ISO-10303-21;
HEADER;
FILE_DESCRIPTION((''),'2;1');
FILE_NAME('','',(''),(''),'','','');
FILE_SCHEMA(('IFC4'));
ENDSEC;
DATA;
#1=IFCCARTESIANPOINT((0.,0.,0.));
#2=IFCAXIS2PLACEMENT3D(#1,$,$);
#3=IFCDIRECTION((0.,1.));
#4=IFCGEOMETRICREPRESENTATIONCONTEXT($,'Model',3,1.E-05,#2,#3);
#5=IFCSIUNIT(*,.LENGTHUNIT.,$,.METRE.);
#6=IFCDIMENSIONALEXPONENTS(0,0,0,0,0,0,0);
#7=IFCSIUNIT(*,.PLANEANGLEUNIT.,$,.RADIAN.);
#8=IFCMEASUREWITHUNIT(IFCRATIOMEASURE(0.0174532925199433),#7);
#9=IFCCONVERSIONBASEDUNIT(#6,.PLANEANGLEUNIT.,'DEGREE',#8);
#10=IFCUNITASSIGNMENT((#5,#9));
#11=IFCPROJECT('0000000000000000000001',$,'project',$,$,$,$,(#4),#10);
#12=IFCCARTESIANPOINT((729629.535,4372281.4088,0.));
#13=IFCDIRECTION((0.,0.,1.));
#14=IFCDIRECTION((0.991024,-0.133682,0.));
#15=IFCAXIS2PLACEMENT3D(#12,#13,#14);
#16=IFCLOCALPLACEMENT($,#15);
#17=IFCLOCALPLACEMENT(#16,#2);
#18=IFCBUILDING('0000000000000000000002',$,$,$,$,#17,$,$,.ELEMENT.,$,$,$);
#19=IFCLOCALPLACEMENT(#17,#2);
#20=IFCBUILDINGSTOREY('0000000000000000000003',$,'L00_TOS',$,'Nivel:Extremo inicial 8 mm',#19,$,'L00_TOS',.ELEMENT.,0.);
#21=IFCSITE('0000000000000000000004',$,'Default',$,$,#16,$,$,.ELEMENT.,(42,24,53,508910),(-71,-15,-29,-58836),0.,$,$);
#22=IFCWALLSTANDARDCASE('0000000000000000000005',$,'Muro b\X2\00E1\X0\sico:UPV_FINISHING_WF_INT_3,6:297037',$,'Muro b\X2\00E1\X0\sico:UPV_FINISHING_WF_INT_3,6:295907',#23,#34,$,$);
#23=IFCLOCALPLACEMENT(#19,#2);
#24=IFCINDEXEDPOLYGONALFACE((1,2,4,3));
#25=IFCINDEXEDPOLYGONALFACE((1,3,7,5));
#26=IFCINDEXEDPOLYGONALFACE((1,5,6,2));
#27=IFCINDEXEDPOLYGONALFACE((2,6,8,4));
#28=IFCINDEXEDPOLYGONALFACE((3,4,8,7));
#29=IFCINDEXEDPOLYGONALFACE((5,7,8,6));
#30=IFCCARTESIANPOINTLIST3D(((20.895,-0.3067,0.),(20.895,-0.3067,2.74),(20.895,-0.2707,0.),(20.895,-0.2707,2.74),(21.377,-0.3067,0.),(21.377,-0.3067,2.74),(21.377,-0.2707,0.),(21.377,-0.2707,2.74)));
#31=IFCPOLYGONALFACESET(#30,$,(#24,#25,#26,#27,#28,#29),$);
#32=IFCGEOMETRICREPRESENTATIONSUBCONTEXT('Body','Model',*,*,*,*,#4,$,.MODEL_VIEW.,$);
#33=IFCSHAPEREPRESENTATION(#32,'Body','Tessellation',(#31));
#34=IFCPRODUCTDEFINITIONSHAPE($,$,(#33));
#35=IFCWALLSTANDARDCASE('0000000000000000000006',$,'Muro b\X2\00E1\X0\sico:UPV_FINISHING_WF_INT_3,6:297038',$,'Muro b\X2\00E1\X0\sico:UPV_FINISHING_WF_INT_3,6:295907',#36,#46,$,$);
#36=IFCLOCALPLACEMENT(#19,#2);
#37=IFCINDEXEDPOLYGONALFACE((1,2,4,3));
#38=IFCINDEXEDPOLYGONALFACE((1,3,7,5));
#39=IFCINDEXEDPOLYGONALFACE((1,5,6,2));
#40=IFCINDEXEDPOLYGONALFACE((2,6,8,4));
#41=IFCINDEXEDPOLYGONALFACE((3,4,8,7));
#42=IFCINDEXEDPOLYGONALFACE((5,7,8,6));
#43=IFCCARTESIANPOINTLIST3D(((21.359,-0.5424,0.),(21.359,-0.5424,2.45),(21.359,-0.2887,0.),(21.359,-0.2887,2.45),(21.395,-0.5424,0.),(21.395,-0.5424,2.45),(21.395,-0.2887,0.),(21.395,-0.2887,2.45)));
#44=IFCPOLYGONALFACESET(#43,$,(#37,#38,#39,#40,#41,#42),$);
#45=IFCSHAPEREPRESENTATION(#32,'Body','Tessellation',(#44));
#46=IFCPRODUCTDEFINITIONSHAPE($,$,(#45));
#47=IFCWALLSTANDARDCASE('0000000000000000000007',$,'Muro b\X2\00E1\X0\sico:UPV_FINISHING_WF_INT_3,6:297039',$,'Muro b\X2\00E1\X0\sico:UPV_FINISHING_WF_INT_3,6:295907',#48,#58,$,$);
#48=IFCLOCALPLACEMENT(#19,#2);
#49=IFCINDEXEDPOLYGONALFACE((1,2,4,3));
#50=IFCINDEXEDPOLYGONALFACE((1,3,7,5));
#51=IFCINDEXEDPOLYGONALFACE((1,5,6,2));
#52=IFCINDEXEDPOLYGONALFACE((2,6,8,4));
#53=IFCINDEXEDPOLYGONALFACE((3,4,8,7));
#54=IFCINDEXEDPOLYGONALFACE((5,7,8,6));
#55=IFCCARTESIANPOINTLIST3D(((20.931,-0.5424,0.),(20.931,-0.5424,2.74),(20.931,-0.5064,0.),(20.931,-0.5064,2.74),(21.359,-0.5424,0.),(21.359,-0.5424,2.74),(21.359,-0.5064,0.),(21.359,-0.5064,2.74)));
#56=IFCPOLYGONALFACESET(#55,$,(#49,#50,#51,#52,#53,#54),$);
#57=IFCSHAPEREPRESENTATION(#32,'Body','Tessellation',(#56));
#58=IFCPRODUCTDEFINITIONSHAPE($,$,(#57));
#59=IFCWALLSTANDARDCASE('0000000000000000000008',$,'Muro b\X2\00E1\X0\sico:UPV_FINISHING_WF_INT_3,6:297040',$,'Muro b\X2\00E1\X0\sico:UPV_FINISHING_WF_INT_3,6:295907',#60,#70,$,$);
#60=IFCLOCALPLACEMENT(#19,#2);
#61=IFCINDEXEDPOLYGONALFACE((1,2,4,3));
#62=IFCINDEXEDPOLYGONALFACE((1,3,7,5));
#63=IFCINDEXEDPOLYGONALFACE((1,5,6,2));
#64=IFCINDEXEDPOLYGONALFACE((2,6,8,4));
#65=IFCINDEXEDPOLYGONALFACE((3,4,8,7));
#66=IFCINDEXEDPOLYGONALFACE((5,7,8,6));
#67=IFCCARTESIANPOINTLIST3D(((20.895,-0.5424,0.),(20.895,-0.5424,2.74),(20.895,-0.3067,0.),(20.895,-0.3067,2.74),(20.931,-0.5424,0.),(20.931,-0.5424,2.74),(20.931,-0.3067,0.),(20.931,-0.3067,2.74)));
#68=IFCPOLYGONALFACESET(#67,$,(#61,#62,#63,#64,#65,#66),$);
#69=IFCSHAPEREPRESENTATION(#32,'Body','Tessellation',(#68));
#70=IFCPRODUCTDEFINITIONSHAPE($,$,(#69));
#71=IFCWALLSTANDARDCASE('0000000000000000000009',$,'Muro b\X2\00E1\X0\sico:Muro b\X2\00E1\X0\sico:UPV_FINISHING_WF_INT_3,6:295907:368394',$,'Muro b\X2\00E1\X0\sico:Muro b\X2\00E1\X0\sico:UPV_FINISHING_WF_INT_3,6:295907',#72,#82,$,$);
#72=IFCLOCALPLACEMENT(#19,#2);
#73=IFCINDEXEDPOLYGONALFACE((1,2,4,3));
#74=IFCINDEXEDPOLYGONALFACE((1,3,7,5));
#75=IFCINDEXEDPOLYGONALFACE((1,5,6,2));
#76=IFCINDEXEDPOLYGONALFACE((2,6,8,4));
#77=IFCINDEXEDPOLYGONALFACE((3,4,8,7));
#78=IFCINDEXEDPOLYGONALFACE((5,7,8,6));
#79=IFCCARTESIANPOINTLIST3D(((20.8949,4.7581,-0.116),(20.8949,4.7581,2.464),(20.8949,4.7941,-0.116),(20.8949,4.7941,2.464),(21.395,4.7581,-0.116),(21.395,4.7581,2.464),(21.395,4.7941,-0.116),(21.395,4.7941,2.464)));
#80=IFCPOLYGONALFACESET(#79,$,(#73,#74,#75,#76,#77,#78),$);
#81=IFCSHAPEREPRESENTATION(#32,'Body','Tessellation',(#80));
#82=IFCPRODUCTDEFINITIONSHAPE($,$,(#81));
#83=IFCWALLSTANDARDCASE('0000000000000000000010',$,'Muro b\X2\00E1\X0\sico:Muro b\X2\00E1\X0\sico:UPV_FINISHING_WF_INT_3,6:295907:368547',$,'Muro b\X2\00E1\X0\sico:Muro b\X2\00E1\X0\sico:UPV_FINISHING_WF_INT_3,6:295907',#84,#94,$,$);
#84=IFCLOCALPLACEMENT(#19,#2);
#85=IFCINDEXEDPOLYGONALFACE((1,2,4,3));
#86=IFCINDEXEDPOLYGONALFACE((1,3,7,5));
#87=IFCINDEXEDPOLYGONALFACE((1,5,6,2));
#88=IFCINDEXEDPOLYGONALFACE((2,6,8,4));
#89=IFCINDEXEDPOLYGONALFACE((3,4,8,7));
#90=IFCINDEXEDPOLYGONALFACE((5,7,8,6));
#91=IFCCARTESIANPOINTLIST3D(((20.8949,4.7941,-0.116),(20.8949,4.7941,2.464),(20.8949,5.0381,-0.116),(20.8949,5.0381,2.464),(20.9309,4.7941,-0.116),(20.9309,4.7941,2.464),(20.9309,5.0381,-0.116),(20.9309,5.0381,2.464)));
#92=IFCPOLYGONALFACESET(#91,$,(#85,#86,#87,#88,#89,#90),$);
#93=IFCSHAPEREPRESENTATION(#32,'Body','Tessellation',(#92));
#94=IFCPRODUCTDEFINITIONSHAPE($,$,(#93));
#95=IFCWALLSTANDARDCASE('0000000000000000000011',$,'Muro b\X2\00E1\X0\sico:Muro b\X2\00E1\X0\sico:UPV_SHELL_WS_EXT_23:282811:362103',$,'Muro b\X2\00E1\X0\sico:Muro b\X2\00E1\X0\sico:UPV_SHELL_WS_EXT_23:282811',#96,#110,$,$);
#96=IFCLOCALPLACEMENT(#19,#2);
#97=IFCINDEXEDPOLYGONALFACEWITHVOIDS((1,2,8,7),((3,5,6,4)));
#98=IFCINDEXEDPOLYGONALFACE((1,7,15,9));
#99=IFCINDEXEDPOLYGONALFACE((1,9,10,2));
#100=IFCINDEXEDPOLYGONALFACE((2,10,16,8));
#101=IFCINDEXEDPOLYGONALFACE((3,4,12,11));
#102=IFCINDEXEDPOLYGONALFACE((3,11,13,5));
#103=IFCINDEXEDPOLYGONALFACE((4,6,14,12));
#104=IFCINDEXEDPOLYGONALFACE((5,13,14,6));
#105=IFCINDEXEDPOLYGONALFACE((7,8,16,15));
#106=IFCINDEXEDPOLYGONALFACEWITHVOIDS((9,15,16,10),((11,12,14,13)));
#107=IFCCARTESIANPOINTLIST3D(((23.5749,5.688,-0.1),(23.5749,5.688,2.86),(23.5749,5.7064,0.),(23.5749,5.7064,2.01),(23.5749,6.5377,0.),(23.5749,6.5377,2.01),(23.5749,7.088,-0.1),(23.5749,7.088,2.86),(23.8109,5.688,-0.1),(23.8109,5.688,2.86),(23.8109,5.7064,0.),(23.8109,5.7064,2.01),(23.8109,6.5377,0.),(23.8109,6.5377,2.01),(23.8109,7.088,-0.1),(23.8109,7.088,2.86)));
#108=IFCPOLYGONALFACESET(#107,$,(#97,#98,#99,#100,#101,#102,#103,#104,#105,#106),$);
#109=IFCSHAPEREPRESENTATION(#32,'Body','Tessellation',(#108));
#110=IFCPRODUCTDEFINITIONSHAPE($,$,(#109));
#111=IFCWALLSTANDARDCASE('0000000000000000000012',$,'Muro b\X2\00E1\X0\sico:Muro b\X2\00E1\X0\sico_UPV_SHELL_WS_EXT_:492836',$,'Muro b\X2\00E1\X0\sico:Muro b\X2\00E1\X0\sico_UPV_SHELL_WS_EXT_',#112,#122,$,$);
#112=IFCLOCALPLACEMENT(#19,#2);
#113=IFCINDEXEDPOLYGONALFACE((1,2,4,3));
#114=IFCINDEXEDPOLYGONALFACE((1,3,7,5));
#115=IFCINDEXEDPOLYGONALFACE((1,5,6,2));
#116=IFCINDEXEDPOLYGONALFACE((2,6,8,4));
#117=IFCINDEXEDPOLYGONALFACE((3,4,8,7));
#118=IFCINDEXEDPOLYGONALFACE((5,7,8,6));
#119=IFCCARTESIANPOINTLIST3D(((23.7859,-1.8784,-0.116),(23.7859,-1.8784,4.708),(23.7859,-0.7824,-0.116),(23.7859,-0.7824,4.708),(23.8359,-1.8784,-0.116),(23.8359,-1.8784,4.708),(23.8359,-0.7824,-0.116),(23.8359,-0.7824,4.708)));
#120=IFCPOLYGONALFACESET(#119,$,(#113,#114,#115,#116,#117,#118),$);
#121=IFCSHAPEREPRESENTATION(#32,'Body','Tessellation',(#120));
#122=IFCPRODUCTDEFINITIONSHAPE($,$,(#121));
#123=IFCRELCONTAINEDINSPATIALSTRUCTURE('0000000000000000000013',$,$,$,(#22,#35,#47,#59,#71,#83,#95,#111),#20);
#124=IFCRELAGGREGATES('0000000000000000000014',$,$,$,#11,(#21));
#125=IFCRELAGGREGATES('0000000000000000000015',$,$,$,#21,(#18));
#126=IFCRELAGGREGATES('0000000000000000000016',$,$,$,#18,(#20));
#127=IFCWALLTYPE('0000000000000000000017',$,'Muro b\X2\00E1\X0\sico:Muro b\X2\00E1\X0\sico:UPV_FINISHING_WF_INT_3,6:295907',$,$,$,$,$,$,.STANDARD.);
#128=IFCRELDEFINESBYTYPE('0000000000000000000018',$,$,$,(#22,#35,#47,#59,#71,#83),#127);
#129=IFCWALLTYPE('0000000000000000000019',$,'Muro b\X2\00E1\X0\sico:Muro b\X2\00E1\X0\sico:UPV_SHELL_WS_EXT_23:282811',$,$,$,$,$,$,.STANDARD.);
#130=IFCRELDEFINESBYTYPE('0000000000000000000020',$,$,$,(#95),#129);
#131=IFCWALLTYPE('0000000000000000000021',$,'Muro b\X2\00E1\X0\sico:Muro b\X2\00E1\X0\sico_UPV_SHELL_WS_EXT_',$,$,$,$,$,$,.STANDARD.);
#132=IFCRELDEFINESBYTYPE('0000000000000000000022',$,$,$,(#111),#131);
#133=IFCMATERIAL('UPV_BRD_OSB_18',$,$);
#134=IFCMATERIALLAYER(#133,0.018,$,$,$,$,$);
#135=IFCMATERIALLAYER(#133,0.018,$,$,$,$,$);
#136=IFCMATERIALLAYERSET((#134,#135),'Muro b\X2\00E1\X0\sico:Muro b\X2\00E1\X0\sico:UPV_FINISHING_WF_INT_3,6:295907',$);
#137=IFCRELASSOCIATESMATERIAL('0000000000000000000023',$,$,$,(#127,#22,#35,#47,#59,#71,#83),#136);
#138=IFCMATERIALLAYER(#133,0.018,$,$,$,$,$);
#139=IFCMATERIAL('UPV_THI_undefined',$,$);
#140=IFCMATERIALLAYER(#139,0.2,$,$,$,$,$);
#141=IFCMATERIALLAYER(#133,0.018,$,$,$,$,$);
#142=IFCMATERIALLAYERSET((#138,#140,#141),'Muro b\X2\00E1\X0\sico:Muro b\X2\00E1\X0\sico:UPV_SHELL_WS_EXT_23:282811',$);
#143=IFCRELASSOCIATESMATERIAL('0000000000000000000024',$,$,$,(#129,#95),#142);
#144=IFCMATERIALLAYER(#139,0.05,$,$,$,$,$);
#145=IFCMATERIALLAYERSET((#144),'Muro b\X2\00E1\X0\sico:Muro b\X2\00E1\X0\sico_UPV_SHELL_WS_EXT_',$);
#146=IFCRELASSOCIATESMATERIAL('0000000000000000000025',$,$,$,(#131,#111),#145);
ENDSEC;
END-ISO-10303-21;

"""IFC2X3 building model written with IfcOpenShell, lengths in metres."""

from ifc_helpers import new_model, entity, si_unit, converted_unit, direction, frame, frame_2d, origin, place, context, subcontext, project, spatial, rectangle, extrude, material, layer, layer_set, layer_usage, type_object, element, save


model = new_model("IFC2X3")

# Units and contexts
model_context = context("Model", 3, precision=1e-05, world=origin(), true_north=direction((0.0, 1.0)))
body_context = subcontext(model_context, "Body", "Model", "MODEL_VIEW")
ifc_project = project(units=[si_unit("LENGTHUNIT", "METRE"), converted_unit("PLANEANGLEUNIT", "DEGREE", entity("IfcRatioMeasure", 0.0174532925199433), si_unit("PLANEANGLEUNIT", "RADIAN"), dimensions=[0, 0, 0, 0, 0, 0, 0])], contexts=[model_context])

# Site, building, storey
site_placement = place(None, frame((729629.535, 4372281.4088, 0.0), z_axis=(0.0, 0.0, 1.0), x_axis=(0.991024, -0.133682, 0.0)))
site = spatial("IfcSite", under=ifc_project, at=site_placement, Name="Default", CompositionType="ELEMENT", RefLatitude=(42, 24, 53, 508910), RefLongitude=(-71, -15, -29, -58836), RefElevation=0.0)
building_placement = place(site_placement, origin())
building = spatial("IfcBuilding", under=site, at=building_placement, CompositionType="ELEMENT")
storey_placement = place(building_placement, origin())
storey = spatial("IfcBuildingStorey", under=building, at=storey_placement, Name="L00_TOS", ObjectType="Nivel:Extremo inicial 8 mm", LongName="L00_TOS", CompositionType="ELEMENT", Elevation=0.0)

# Walls
ifc_material_1 = material(Name="UPV_BRD_OSB_18")
ifc_layer_1 = layer(ifc_material_1, 0.018)
ifc_layer_2 = layer(ifc_material_1, 0.018)
ifc_layer_set_1 = layer_set([ifc_layer_1, ifc_layer_2], Name="Muro básico:Muro básico:UPV_FINISHING_WF_INT_3,6:295907")
ifc_layer_usage_1 = layer_usage(ifc_layer_set_1, "AXIS2", "NEGATIVE", 0.018)
wall_type_1 = type_object("IfcWallType", Name="Muro básico:Muro básico:UPV_FINISHING_WF_INT_3,6:295907", PredefinedType="STANDARD", material=ifc_layer_set_1)
wall_1_placement = place(storey_placement, frame((20.895, -0.2887, 0.0)))
element("IfcWallStandardCase", 1, at=wall_1_placement, inside=storey, type_object=wall_type_1, material=ifc_layer_usage_1, Name="Muro básico:UPV_FINISHING_WF_INT_3,6:297037", ObjectType="Muro básico:UPV_FINISHING_WF_INT_3,6:295907", context=body_context, shape_type="SweptSolid", body=[
    extrude(rectangle(XDim=0.482, YDim=0.036, at=frame_2d((0.241, 0.0), x_axis=(-1.0, 0.0))), origin(), (0.0, 0.0, 1.0), 2.74),
])
ifc_layer_usage_2 = layer_usage(ifc_layer_set_1, "AXIS2", "NEGATIVE", 0.018)
wall_2_placement = place(storey_placement, frame((21.377, -0.2887, 0.0), z_axis=(0.0, 0.0, 1.0), x_axis=(0.0, -1.0, 0.0)))
element("IfcWallStandardCase", 2, at=wall_2_placement, inside=storey, type_object=wall_type_1, material=ifc_layer_usage_2, Name="Muro básico:UPV_FINISHING_WF_INT_3,6:297038", ObjectType="Muro básico:UPV_FINISHING_WF_INT_3,6:295907", context=body_context, shape_type="SweptSolid", body=[
    extrude(rectangle(XDim=0.2537, YDim=0.036, at=frame_2d((0.1268, 0.0), x_axis=(-1.0, 0.0))), origin(), (0.0, 0.0, 1.0), 2.45),
])
ifc_layer_usage_3 = layer_usage(ifc_layer_set_1, "AXIS2", "NEGATIVE", 0.018)
wall_3_placement = place(storey_placement, frame((21.359, -0.5244, 0.0), z_axis=(0.0, 0.0, 1.0), x_axis=(-1.0, 0.0, 0.0)))
element("IfcWallStandardCase", 3, at=wall_3_placement, inside=storey, type_object=wall_type_1, material=ifc_layer_usage_3, Name="Muro básico:UPV_FINISHING_WF_INT_3,6:297039", ObjectType="Muro básico:UPV_FINISHING_WF_INT_3,6:295907", context=body_context, shape_type="SweptSolid", body=[
    extrude(rectangle(XDim=0.428, YDim=0.036, at=frame_2d((0.214, 0.0), x_axis=(-1.0, 0.0))), origin(), (0.0, 0.0, 1.0), 2.74),
])
ifc_layer_usage_4 = layer_usage(ifc_layer_set_1, "AXIS2", "NEGATIVE", 0.018)
wall_4_placement = place(storey_placement, frame((20.913, -0.5424, 0.0), z_axis=(0.0, 0.0, 1.0), x_axis=(0.0, 1.0, 0.0)))
element("IfcWallStandardCase", 4, at=wall_4_placement, inside=storey, type_object=wall_type_1, material=ifc_layer_usage_4, Name="Muro básico:UPV_FINISHING_WF_INT_3,6:297040", ObjectType="Muro básico:UPV_FINISHING_WF_INT_3,6:295907", context=body_context, shape_type="SweptSolid", body=[
    extrude(rectangle(XDim=0.2357, YDim=0.036, at=frame_2d((0.1178, 0.0), x_axis=(-1.0, 0.0))), origin(), (0.0, 0.0, 1.0), 2.74),
])
ifc_layer_usage_5 = layer_usage(ifc_layer_set_1, "AXIS2", "NEGATIVE", 0.018)
wall_5_placement = place(storey_placement, frame((21.395, 4.7761, -0.116), z_axis=(0.0, 0.0, 1.0), x_axis=(-1.0, 0.0, 0.0)))
element("IfcWallStandardCase", 5, at=wall_5_placement, inside=storey, type_object=wall_type_1, material=ifc_layer_usage_5, Name="Muro básico:Muro básico:UPV_FINISHING_WF_INT_3,6:295907:368394", ObjectType="Muro básico:Muro básico:UPV_FINISHING_WF_INT_3,6:295907", context=body_context, shape_type="SweptSolid", body=[
    extrude(rectangle(XDim=0.5002, YDim=0.036, at=frame_2d((0.2501, 0.0), x_axis=(-1.0, 0.0))), origin(), (0.0, 0.0, 1.0), 2.58),
])
ifc_layer_usage_6 = layer_usage(ifc_layer_set_1, "AXIS2", "NEGATIVE", 0.018)
wall_6_placement = place(storey_placement, frame((20.9129, 4.7941, -0.116), z_axis=(0.0, 0.0, 1.0), x_axis=(0.0, 1.0, 0.0)))
element("IfcWallStandardCase", 6, at=wall_6_placement, inside=storey, type_object=wall_type_1, material=ifc_layer_usage_6, Name="Muro básico:Muro básico:UPV_FINISHING_WF_INT_3,6:295907:368547", ObjectType="Muro básico:Muro básico:UPV_FINISHING_WF_INT_3,6:295907", context=body_context, shape_type="SweptSolid", body=[
    extrude(rectangle(XDim=0.244, YDim=0.036, at=frame_2d((0.122, 0.0), x_axis=(-1.0, 0.0))), origin(), (0.0, 0.0, 1.0), 2.58),
])

# Wall, opening
ifc_layer_3 = layer(ifc_material_1, 0.018)
ifc_material_2 = material(Name="UPV_THI_undefined")
ifc_layer_4 = layer(ifc_material_2, 0.2)
ifc_layer_5 = layer(ifc_material_1, 0.018)
ifc_layer_set_2 = layer_set([ifc_layer_3, ifc_layer_4, ifc_layer_5], Name="Muro básico:Muro básico:UPV_SHELL_WS_EXT_23:282811")
ifc_layer_usage_7 = layer_usage(ifc_layer_set_2, "AXIS2", "NEGATIVE", 0.118)
wall_type_2 = type_object("IfcWallType", Name="Muro básico:Muro básico:UPV_SHELL_WS_EXT_23:282811", PredefinedType="STANDARD", material=ifc_layer_set_2)
wall_7_placement = place(storey_placement, frame((23.6929, 7.088, -0.1), z_axis=(0.0, 0.0, 1.0), x_axis=(0.0, -1.0, 0.0)))
wall_7 = element("IfcWallStandardCase", 7, at=wall_7_placement, inside=storey, type_object=wall_type_2, material=ifc_layer_usage_7, Name="Muro básico:Muro básico:UPV_SHELL_WS_EXT_23:282811:362103", ObjectType="Muro básico:Muro básico:UPV_SHELL_WS_EXT_23:282811", context=body_context, shape_type="SweptSolid", body=[
    extrude(rectangle(XDim=1.4, YDim=0.236, at=frame_2d((0.7, 0.0), x_axis=(-1.0, 0.0))), origin(), (0.0, 0.0, 1.0), 2.96),
])
opening_1_placement = place(wall_7_placement, origin())
element("IfcOpeningElement", 8, at=opening_1_placement, cuts=wall_7, ObjectType="Opening", context=body_context, shape_type="SweptSolid", body=[
    extrude(rectangle(XDim=2.01, YDim=0.8314, at=frame_2d((0.0, 0.0), x_axis=(0.0, 1.0))), frame((0.966, 0.118, 1.105), z_axis=(0.0, -1.0, 0.0), x_axis=(-1.0, 0.0, 0.0)), (0.0, 0.0, 1.0), 0.236),
])

# Wall
ifc_layer_6 = layer(ifc_material_2, 0.05)
ifc_layer_set_3 = layer_set([ifc_layer_6], Name="Muro básico:Muro básico_UPV_SHELL_WS_EXT_")
ifc_layer_usage_8 = layer_usage(ifc_layer_set_3, "AXIS2", "NEGATIVE", 0.025)
wall_type_3 = type_object("IfcWallType", Name="Muro básico:Muro básico_UPV_SHELL_WS_EXT_", PredefinedType="STANDARD", material=ifc_layer_set_3)
wall_8_placement = place(storey_placement, frame((23.8109, -0.7824, -0.116), z_axis=(0.0, 0.0, 1.0), x_axis=(0.0, -1.0, 0.0)))
element("IfcWallStandardCase", 9, at=wall_8_placement, inside=storey, type_object=wall_type_3, material=ifc_layer_usage_8, Name="Muro básico:Muro básico_UPV_SHELL_WS_EXT_:492836", ObjectType="Muro básico:Muro básico_UPV_SHELL_WS_EXT_", context=body_context, shape_type="SweptSolid", body=[
    extrude(rectangle(XDim=1.096, YDim=0.05, at=frame_2d((0.548, 0.0), x_axis=(-1.0, 0.0))), origin(), (0.0, 0.0, 1.0), 4.824),
])

save(model, "model.ifc")
